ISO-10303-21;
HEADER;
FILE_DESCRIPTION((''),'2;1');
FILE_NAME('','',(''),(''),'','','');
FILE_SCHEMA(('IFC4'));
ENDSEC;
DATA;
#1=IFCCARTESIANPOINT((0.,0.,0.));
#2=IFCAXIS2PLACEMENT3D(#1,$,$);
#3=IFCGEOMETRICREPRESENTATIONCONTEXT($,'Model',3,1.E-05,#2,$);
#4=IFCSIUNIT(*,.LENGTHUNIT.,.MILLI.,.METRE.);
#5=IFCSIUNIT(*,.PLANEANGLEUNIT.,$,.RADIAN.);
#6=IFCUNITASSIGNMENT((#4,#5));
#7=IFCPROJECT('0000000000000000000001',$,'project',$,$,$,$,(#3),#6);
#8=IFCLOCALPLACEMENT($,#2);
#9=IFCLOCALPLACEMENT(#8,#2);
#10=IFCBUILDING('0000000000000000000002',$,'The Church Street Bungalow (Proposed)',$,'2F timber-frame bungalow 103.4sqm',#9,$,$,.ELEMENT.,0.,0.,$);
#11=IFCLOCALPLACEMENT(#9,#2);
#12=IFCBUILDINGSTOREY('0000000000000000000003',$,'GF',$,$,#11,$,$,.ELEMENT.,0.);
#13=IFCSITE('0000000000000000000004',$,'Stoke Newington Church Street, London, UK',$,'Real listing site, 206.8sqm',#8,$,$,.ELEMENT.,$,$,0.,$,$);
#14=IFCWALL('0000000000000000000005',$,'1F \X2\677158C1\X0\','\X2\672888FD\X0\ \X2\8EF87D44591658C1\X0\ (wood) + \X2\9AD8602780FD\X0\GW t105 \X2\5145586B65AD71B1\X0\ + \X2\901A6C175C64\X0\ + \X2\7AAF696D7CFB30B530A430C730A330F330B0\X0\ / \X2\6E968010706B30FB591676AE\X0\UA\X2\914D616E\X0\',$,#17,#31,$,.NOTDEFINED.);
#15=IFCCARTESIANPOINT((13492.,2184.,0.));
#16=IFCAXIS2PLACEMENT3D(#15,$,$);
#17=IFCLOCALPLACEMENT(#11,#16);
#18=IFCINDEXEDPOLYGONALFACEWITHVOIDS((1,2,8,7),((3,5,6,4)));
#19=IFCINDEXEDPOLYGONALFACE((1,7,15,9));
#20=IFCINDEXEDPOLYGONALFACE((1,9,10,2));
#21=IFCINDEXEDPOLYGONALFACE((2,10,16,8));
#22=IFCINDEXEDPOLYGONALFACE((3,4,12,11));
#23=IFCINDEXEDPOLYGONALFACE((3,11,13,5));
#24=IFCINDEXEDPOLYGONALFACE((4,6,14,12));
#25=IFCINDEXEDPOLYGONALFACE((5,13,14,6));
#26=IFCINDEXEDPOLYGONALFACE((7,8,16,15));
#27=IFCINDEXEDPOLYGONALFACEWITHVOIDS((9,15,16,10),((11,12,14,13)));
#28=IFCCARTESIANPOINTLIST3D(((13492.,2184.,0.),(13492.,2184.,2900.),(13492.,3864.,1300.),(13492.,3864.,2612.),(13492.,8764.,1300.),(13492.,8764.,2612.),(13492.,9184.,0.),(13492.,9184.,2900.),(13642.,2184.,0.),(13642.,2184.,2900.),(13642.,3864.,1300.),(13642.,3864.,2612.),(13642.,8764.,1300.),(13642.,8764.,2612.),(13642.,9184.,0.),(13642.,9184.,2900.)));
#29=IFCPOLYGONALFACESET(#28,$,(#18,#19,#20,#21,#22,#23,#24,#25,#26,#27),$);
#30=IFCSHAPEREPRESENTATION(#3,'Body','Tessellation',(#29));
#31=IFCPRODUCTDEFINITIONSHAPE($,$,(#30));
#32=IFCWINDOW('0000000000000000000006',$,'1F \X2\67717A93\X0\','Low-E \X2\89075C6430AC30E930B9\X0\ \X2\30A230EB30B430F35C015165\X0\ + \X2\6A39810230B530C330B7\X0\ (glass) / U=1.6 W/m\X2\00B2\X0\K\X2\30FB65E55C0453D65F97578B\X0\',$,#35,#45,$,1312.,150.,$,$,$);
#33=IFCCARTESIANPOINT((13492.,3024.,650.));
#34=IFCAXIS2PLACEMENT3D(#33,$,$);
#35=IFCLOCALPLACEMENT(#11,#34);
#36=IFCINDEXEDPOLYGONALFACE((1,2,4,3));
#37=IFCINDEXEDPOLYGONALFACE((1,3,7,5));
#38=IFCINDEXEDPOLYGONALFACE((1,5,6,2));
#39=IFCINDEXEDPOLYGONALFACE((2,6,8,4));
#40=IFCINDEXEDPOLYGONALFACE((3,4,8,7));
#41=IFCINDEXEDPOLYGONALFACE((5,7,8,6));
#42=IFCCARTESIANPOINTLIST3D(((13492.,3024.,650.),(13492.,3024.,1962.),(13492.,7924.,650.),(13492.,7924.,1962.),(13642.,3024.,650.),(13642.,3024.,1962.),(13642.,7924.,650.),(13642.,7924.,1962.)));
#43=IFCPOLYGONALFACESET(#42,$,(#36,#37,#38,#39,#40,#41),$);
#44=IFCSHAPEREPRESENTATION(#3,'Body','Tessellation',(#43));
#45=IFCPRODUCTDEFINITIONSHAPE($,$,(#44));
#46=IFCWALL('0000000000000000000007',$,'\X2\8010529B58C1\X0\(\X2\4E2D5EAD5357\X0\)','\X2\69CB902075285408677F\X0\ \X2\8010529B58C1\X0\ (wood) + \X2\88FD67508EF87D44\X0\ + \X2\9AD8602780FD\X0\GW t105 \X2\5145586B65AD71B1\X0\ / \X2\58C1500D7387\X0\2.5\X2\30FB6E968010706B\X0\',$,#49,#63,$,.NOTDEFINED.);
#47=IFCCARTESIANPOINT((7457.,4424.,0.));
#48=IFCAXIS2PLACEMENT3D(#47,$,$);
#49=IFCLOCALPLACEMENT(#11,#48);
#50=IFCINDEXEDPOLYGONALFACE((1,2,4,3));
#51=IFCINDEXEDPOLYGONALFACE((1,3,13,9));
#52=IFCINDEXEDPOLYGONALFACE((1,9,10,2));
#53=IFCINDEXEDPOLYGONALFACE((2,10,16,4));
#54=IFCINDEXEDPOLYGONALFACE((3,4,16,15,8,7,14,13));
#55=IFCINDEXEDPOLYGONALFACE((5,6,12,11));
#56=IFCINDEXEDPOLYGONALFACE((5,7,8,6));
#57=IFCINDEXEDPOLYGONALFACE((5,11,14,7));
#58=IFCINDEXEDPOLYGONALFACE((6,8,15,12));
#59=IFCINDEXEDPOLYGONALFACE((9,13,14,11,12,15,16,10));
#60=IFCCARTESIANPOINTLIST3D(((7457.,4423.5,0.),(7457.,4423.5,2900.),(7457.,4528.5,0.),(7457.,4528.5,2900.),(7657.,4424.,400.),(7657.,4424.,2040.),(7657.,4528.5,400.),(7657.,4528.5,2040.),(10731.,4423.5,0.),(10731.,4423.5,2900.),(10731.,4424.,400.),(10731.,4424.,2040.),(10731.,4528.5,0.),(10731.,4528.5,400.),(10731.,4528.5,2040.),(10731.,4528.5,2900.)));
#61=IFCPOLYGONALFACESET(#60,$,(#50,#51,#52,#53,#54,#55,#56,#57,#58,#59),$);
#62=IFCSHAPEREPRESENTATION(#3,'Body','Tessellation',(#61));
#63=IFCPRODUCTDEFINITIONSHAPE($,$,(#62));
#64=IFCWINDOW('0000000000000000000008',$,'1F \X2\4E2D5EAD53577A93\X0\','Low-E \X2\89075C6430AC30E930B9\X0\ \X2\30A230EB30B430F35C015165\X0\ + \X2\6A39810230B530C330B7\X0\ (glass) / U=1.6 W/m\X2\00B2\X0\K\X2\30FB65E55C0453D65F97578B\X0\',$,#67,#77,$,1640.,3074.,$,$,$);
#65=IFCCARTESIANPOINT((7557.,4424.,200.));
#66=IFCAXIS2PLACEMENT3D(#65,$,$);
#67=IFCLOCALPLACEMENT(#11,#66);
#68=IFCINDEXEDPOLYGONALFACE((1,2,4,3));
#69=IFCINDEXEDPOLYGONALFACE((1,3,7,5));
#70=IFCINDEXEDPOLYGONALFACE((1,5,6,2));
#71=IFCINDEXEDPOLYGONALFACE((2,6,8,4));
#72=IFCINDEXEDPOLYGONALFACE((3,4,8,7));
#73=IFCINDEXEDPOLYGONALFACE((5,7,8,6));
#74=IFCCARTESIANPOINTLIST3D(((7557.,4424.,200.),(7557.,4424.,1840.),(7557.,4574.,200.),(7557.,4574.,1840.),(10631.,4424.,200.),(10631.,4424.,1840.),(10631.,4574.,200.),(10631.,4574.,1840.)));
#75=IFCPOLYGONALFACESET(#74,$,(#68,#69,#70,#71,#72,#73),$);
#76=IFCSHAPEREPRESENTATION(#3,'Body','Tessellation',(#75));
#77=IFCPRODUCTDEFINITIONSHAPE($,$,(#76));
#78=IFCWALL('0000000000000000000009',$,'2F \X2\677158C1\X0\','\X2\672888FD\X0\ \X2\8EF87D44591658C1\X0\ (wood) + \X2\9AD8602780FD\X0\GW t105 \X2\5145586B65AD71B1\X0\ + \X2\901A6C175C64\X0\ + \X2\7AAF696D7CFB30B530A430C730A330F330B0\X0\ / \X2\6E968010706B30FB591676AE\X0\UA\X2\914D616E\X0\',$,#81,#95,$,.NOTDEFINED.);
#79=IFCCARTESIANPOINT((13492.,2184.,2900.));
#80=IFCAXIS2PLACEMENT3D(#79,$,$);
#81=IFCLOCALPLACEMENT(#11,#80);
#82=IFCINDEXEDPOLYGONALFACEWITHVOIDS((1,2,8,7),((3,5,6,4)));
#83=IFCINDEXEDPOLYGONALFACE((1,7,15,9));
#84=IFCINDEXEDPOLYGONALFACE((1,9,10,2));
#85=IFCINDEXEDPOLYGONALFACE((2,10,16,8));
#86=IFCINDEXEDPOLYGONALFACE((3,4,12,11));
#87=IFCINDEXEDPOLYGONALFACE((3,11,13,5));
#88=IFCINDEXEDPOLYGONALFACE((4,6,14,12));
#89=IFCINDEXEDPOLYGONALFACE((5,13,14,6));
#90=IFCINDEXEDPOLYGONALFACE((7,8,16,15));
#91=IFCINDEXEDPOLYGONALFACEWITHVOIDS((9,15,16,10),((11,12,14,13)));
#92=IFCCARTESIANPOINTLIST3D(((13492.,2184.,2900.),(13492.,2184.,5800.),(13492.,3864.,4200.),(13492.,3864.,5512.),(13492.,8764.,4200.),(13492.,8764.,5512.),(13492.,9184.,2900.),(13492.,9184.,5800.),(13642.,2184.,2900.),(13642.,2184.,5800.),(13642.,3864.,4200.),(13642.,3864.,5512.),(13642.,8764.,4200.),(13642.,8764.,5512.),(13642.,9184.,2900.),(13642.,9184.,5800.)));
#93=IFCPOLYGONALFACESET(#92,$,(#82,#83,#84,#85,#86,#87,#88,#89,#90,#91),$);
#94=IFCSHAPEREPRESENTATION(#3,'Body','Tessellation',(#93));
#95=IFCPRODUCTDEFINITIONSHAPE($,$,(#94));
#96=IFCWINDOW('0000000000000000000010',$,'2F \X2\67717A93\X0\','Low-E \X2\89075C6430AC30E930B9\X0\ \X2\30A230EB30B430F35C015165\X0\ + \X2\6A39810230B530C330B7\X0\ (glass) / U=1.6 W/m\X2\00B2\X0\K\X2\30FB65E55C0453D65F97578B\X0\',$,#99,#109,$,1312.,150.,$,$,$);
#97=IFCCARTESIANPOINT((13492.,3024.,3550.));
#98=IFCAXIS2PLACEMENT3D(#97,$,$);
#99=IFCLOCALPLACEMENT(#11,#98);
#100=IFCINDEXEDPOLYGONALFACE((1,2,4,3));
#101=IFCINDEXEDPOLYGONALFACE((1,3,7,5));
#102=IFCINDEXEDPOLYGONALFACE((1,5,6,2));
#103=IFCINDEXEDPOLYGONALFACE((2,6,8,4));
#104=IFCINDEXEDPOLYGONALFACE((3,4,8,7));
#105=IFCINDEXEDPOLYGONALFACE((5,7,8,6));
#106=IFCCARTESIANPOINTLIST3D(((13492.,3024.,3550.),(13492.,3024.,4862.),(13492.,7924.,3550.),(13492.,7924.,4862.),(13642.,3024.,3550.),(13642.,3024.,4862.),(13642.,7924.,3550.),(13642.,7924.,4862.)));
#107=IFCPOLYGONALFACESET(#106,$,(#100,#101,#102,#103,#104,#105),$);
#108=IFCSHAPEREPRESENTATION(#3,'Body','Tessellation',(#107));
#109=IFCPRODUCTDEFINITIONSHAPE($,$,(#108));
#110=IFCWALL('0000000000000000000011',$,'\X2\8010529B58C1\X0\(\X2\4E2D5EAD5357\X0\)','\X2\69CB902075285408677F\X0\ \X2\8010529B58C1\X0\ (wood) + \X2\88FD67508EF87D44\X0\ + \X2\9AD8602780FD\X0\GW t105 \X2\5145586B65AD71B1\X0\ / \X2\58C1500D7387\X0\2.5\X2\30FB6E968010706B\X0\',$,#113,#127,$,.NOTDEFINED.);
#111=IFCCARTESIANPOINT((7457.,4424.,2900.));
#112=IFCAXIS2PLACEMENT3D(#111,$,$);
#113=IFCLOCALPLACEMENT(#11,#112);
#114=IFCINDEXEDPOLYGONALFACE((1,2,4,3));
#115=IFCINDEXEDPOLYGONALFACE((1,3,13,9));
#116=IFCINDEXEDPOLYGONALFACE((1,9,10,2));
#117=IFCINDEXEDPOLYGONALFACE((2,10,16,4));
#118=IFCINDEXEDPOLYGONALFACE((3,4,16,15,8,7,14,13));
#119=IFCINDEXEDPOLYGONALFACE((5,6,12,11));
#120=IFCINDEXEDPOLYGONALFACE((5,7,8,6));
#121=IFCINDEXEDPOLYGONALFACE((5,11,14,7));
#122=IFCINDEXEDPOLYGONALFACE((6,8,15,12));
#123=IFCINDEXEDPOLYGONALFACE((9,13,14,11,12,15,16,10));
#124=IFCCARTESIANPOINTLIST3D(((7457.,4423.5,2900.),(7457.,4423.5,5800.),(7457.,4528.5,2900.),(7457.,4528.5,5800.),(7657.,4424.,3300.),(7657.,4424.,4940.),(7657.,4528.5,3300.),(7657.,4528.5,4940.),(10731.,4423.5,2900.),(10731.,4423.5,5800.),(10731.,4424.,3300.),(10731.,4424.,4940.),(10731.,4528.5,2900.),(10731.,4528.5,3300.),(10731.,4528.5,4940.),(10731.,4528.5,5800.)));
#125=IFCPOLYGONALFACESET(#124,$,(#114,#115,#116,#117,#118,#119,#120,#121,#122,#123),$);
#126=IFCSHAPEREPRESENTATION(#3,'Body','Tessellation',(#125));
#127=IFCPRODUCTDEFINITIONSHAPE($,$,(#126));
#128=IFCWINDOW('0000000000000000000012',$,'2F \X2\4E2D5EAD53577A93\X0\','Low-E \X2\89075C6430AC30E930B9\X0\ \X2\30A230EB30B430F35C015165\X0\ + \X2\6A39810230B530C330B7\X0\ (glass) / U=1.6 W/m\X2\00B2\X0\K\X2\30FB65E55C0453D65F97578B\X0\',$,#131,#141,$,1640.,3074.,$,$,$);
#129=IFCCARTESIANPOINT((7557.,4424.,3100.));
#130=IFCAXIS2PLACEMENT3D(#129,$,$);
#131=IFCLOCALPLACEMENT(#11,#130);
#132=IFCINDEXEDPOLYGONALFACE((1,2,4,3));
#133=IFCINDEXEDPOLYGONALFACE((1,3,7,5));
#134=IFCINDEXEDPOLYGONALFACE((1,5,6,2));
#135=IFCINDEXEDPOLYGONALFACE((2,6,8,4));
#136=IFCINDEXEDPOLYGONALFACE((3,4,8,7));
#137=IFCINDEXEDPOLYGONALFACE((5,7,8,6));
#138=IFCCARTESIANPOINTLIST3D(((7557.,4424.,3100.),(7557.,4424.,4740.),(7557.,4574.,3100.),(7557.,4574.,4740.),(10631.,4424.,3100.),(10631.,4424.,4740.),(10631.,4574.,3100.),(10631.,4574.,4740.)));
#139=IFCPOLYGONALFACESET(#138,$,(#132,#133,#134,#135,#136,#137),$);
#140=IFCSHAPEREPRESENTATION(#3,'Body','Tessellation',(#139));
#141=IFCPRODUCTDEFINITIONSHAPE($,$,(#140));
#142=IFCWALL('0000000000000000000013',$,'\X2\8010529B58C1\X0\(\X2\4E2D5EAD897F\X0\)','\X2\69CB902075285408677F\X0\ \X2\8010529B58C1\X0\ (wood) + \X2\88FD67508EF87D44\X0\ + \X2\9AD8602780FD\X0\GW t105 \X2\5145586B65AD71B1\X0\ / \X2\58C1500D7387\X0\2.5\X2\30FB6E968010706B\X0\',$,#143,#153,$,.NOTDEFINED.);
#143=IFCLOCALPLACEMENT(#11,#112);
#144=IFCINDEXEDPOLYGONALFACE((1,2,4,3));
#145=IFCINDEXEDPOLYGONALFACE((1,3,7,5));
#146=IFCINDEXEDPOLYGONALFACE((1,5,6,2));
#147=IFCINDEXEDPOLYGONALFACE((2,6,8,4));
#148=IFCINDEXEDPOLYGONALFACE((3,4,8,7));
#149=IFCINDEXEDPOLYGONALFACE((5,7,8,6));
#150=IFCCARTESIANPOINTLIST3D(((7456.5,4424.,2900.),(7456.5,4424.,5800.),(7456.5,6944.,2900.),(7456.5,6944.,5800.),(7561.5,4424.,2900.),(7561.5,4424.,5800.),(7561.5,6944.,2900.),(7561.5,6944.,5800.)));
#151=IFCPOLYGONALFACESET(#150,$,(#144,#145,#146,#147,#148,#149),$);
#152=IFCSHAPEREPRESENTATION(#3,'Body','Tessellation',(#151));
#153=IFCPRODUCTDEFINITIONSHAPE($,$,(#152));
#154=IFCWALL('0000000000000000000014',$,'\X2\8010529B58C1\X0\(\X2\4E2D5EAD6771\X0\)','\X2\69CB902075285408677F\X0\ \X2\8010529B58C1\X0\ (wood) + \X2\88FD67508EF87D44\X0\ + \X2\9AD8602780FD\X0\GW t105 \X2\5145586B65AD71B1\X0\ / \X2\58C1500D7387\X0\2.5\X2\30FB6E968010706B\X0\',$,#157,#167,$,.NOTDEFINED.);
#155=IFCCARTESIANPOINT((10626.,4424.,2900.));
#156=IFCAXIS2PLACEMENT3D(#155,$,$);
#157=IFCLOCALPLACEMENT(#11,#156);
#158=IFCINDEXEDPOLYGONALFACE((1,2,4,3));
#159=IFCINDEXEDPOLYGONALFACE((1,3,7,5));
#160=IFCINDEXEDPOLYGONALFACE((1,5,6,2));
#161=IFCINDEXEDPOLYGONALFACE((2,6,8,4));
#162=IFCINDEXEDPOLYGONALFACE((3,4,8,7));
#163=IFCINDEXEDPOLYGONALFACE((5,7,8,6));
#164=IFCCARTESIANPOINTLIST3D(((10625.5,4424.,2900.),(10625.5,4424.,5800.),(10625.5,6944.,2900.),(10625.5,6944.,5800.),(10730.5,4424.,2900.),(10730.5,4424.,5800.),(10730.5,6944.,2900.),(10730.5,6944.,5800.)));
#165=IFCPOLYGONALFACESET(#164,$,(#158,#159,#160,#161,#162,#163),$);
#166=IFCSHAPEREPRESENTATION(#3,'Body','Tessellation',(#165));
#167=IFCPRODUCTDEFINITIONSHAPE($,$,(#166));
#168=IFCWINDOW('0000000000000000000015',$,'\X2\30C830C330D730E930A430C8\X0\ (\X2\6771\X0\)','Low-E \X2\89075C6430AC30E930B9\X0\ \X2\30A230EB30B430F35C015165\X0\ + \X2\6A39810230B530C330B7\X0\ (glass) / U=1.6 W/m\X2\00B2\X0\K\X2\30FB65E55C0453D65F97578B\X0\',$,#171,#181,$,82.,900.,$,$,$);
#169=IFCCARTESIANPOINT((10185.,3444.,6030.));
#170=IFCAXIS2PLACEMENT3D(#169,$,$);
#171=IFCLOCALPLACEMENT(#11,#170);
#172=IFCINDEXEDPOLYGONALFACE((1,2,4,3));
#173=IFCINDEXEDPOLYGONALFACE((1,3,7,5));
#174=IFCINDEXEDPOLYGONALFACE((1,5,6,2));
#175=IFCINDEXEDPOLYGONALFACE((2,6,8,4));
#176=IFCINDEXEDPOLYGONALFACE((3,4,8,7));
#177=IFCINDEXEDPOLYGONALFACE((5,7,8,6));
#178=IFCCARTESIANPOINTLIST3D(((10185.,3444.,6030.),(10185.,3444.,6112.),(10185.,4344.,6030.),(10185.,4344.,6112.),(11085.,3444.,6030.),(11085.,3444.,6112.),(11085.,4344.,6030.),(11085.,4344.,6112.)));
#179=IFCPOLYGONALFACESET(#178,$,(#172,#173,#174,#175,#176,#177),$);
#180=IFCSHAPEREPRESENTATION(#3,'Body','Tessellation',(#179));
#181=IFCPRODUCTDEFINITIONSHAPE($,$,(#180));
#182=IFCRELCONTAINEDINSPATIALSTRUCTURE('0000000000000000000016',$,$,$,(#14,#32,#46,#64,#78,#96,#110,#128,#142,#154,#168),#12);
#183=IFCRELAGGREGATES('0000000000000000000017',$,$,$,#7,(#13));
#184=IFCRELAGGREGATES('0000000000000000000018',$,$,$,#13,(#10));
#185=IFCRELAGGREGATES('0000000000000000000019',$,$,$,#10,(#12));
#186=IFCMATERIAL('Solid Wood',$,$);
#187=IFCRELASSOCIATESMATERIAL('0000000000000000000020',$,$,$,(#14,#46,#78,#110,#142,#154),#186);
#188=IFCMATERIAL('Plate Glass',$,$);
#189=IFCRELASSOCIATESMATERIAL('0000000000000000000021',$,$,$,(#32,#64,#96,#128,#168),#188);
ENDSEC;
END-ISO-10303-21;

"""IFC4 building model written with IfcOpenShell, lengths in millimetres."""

from ifc_helpers import new_model, si_unit, frame, frame_2d, origin, place, context, project, spatial, rectangle, extrude, material, element, fill, save


model = new_model("IFC4")

# Units and contexts
model_context = context("Model", 3, precision=1e-05, world=origin())
ifc_project = project(units=[si_unit("LENGTHUNIT", "METRE", prefix="MILLI"), si_unit("PLANEANGLEUNIT", "RADIAN")], contexts=[model_context])

# Site, building, storey
site_placement = place(None, origin())
site = spatial("IfcSite", under=ifc_project, at=site_placement, Name="Stoke Newington Church Street, London, UK", ObjectType="Real listing site, 206.8sqm", CompositionType="ELEMENT", RefElevation=0.0)
building_placement = place(site_placement, origin())
building = spatial("IfcBuilding", under=site, at=building_placement, Name="The Church Street Bungalow (Proposed)", ObjectType="2F timber-frame bungalow 103.4sqm", CompositionType="ELEMENT", ElevationOfRefHeight=0.0, ElevationOfTerrain=0.0)
storey_placement = place(building_placement, origin())
storey = spatial("IfcBuildingStorey", under=building, at=storey_placement, Name="GF", CompositionType="ELEMENT", Elevation=0.0)

# Shared definitions
ifc_material_1 = material(Name="Solid Wood")

# Walls, openings, windows
wall_1_placement = place(storey_placement, frame((13492.0, 2184.0, 0.0)))
wall_1 = element("IfcWall", 1, at=wall_1_placement, inside=storey, material=ifc_material_1, Name="1F 東壁", Description="木製 軸組外壁 (wood) + 高性能GW t105 充填断熱 + 通気層 + 窯業系サイディング / 準耐火・外皮UA配慮", PredefinedType="NOTDEFINED", context=model_context, shape_type="SweptSolid", body=[
    extrude(rectangle(XDim=150.0, YDim=7000.0, at=frame_2d((75.0, 3500.0))), frame((13492.0, 2184.0, 0.0)), (0.0, 0.0, 1.0), 2900.0),
])
opening_1_placement = place(storey_placement, frame((13492.0, 3024.0, 650.0)))
opening_1 = element("IfcOpeningElement", 2, at=opening_1_placement, cuts=wall_1, PredefinedType="NOTDEFINED", context=model_context, shape_type="SweptSolid", body=[
    extrude(rectangle(XDim=150.0, YDim=4900.0, at=frame_2d((75.0, 2450.0))), frame((13492.0, 3024.0, 650.0)), (0.0, 0.0, 1.0), 1312.0),
])
ifc_material_2 = material(Name="Plate Glass")
window_1_placement = place(storey_placement, frame((13492.0, 3024.0, 650.0)))
window_1 = element("IfcWindow", 3, at=window_1_placement, inside=storey, material=ifc_material_2, Name="1F 東窓", Description="Low-E 複層ガラス アルゴン封入 + 樹脂サッシ (glass) / U=1.6 W/m²K・日射取得型", OverallHeight=1312.0, OverallWidth=150.0, context=model_context, shape_type="SweptSolid", body=[
    extrude(rectangle(XDim=150.0, YDim=4900.0, at=frame_2d((75.0, 2450.0))), frame((13492.0, 3024.0, 650.0)), (0.0, 0.0, 1.0), 1312.0),
])
fill(opening_1, window_1)
wall_2_placement = place(storey_placement, frame((7457.0, 4424.0, 0.0)))
wall_2 = element("IfcWall", 4, at=wall_2_placement, inside=storey, material=ifc_material_1, Name="耐力壁(中庭南)", Description="構造用合板 耐力壁 (wood) + 製材軸組 + 高性能GW t105 充填断熱 / 壁倍率2.5・準耐火", PredefinedType="NOTDEFINED", context=model_context, shape_type="SweptSolid", body=[
    extrude(rectangle(XDim=3274.0, YDim=105.0, at=frame_2d((1637.0, 52.0))), frame((7457.0, 4424.0, 0.0)), (0.0, 0.0, 1.0), 2900.0),
])
opening_2_placement = place(storey_placement, frame((7557.0, 4424.0, 200.0)))
opening_2 = element("IfcOpeningElement", 5, at=opening_2_placement, cuts=wall_2, PredefinedType="NOTDEFINED", context=model_context, shape_type="SweptSolid", body=[
    extrude(rectangle(XDim=3074.0, YDim=150.0, at=frame_2d((1537.0, 75.0))), frame((7557.0, 4424.0, 200.0)), (0.0, 0.0, 1.0), 1640.0),
])
window_2_placement = place(storey_placement, frame((7557.0, 4424.0, 200.0)))
window_2 = element("IfcWindow", 6, at=window_2_placement, inside=storey, material=ifc_material_2, Name="1F 中庭南窓", Description="Low-E 複層ガラス アルゴン封入 + 樹脂サッシ (glass) / U=1.6 W/m²K・日射取得型", OverallHeight=1640.0, OverallWidth=3074.0, context=model_context, shape_type="SweptSolid", body=[
    extrude(rectangle(XDim=3074.0, YDim=150.0, at=frame_2d((1537.0, 75.0))), frame((7557.0, 4424.0, 200.0)), (0.0, 0.0, 1.0), 1640.0),
])
fill(opening_2, window_2)

# Walls, openings, windows
wall_3_placement = place(storey_placement, frame((13492.0, 2184.0, 2900.0)))
wall_3 = element("IfcWall", 7, at=wall_3_placement, inside=storey, material=ifc_material_1, Name="2F 東壁", Description="木製 軸組外壁 (wood) + 高性能GW t105 充填断熱 + 通気層 + 窯業系サイディング / 準耐火・外皮UA配慮", PredefinedType="NOTDEFINED", context=model_context, shape_type="SweptSolid", body=[
    extrude(rectangle(XDim=150.0, YDim=7000.0, at=frame_2d((75.0, 3500.0))), frame((13492.0, 2184.0, 2900.0)), (0.0, 0.0, 1.0), 2900.0),
])
opening_3_placement = place(storey_placement, frame((13492.0, 3024.0, 3550.0)))
opening_3 = element("IfcOpeningElement", 8, at=opening_3_placement, cuts=wall_3, PredefinedType="NOTDEFINED", context=model_context, shape_type="SweptSolid", body=[
    extrude(rectangle(XDim=150.0, YDim=4900.0, at=frame_2d((75.0, 2450.0))), frame((13492.0, 3024.0, 3550.0)), (0.0, 0.0, 1.0), 1312.0),
])
window_3_placement = place(storey_placement, frame((13492.0, 3024.0, 3550.0)))
window_3 = element("IfcWindow", 9, at=window_3_placement, inside=storey, material=ifc_material_2, Name="2F 東窓", Description="Low-E 複層ガラス アルゴン封入 + 樹脂サッシ (glass) / U=1.6 W/m²K・日射取得型", OverallHeight=1312.0, OverallWidth=150.0, context=model_context, shape_type="SweptSolid", body=[
    extrude(rectangle(XDim=150.0, YDim=4900.0, at=frame_2d((75.0, 2450.0))), frame((13492.0, 3024.0, 3550.0)), (0.0, 0.0, 1.0), 1312.0),
])
fill(opening_3, window_3)
wall_4_placement = place(storey_placement, frame((7457.0, 4424.0, 2900.0)))
wall_4 = element("IfcWall", 10, at=wall_4_placement, inside=storey, material=ifc_material_1, Name="耐力壁(中庭南)", Description="構造用合板 耐力壁 (wood) + 製材軸組 + 高性能GW t105 充填断熱 / 壁倍率2.5・準耐火", PredefinedType="NOTDEFINED", context=model_context, shape_type="SweptSolid", body=[
    extrude(rectangle(XDim=3274.0, YDim=105.0, at=frame_2d((1637.0, 52.0))), frame((7457.0, 4424.0, 2900.0)), (0.0, 0.0, 1.0), 2900.0),
])
opening_4_placement = place(storey_placement, frame((7557.0, 4424.0, 3100.0)))
opening_4 = element("IfcOpeningElement", 11, at=opening_4_placement, cuts=wall_4, PredefinedType="NOTDEFINED", context=model_context, shape_type="SweptSolid", body=[
    extrude(rectangle(XDim=3074.0, YDim=150.0, at=frame_2d((1537.0, 75.0))), frame((7557.0, 4424.0, 3100.0)), (0.0, 0.0, 1.0), 1640.0),
])
window_4_placement = place(storey_placement, frame((7557.0, 4424.0, 3100.0)))
window_4 = element("IfcWindow", 12, at=window_4_placement, inside=storey, material=ifc_material_2, Name="2F 中庭南窓", Description="Low-E 複層ガラス アルゴン封入 + 樹脂サッシ (glass) / U=1.6 W/m²K・日射取得型", OverallHeight=1640.0, OverallWidth=3074.0, context=model_context, shape_type="SweptSolid", body=[
    extrude(rectangle(XDim=3074.0, YDim=150.0, at=frame_2d((1537.0, 75.0))), frame((7557.0, 4424.0, 3100.0)), (0.0, 0.0, 1.0), 1640.0),
])
fill(opening_4, window_4)

# Walls
wall_5_placement = place(storey_placement, frame((7457.0, 4424.0, 2900.0)))
element("IfcWall", 13, at=wall_5_placement, inside=storey, material=ifc_material_1, Name="耐力壁(中庭西)", Description="構造用合板 耐力壁 (wood) + 製材軸組 + 高性能GW t105 充填断熱 / 壁倍率2.5・準耐火", PredefinedType="NOTDEFINED", context=model_context, shape_type="SweptSolid", body=[
    extrude(rectangle(XDim=105.0, YDim=2520.0, at=frame_2d((52.0, 1260.0))), frame((7457.0, 4424.0, 2900.0)), (0.0, 0.0, 1.0), 2900.0),
])
wall_6_placement = place(storey_placement, frame((10626.0, 4424.0, 2900.0)))
element("IfcWall", 14, at=wall_6_placement, inside=storey, material=ifc_material_1, Name="耐力壁(中庭東)", Description="構造用合板 耐力壁 (wood) + 製材軸組 + 高性能GW t105 充填断熱 / 壁倍率2.5・準耐火", PredefinedType="NOTDEFINED", context=model_context, shape_type="SweptSolid", body=[
    extrude(rectangle(XDim=105.0, YDim=2520.0, at=frame_2d((52.0, 1260.0))), frame((10626.0, 4424.0, 2900.0)), (0.0, 0.0, 1.0), 2900.0),
])

# Window
window_5_placement = place(storey_placement, frame((10185.0, 3444.0, 6030.0)))
element("IfcWindow", 15, at=window_5_placement, inside=storey, material=ifc_material_2, Name="トップライト (東)", Description="Low-E 複層ガラス アルゴン封入 + 樹脂サッシ (glass) / U=1.6 W/m²K・日射取得型", OverallHeight=82.0, OverallWidth=900.0, context=model_context, shape_type="SweptSolid", body=[
    extrude(rectangle(XDim=900.0, YDim=900.0, at=frame_2d((450.0, 450.0))), frame((10185.0, 3444.0, 6030.0)), (0.0, 0.0, 1.0), 82.0),
])

save(model, "model.ifc")
